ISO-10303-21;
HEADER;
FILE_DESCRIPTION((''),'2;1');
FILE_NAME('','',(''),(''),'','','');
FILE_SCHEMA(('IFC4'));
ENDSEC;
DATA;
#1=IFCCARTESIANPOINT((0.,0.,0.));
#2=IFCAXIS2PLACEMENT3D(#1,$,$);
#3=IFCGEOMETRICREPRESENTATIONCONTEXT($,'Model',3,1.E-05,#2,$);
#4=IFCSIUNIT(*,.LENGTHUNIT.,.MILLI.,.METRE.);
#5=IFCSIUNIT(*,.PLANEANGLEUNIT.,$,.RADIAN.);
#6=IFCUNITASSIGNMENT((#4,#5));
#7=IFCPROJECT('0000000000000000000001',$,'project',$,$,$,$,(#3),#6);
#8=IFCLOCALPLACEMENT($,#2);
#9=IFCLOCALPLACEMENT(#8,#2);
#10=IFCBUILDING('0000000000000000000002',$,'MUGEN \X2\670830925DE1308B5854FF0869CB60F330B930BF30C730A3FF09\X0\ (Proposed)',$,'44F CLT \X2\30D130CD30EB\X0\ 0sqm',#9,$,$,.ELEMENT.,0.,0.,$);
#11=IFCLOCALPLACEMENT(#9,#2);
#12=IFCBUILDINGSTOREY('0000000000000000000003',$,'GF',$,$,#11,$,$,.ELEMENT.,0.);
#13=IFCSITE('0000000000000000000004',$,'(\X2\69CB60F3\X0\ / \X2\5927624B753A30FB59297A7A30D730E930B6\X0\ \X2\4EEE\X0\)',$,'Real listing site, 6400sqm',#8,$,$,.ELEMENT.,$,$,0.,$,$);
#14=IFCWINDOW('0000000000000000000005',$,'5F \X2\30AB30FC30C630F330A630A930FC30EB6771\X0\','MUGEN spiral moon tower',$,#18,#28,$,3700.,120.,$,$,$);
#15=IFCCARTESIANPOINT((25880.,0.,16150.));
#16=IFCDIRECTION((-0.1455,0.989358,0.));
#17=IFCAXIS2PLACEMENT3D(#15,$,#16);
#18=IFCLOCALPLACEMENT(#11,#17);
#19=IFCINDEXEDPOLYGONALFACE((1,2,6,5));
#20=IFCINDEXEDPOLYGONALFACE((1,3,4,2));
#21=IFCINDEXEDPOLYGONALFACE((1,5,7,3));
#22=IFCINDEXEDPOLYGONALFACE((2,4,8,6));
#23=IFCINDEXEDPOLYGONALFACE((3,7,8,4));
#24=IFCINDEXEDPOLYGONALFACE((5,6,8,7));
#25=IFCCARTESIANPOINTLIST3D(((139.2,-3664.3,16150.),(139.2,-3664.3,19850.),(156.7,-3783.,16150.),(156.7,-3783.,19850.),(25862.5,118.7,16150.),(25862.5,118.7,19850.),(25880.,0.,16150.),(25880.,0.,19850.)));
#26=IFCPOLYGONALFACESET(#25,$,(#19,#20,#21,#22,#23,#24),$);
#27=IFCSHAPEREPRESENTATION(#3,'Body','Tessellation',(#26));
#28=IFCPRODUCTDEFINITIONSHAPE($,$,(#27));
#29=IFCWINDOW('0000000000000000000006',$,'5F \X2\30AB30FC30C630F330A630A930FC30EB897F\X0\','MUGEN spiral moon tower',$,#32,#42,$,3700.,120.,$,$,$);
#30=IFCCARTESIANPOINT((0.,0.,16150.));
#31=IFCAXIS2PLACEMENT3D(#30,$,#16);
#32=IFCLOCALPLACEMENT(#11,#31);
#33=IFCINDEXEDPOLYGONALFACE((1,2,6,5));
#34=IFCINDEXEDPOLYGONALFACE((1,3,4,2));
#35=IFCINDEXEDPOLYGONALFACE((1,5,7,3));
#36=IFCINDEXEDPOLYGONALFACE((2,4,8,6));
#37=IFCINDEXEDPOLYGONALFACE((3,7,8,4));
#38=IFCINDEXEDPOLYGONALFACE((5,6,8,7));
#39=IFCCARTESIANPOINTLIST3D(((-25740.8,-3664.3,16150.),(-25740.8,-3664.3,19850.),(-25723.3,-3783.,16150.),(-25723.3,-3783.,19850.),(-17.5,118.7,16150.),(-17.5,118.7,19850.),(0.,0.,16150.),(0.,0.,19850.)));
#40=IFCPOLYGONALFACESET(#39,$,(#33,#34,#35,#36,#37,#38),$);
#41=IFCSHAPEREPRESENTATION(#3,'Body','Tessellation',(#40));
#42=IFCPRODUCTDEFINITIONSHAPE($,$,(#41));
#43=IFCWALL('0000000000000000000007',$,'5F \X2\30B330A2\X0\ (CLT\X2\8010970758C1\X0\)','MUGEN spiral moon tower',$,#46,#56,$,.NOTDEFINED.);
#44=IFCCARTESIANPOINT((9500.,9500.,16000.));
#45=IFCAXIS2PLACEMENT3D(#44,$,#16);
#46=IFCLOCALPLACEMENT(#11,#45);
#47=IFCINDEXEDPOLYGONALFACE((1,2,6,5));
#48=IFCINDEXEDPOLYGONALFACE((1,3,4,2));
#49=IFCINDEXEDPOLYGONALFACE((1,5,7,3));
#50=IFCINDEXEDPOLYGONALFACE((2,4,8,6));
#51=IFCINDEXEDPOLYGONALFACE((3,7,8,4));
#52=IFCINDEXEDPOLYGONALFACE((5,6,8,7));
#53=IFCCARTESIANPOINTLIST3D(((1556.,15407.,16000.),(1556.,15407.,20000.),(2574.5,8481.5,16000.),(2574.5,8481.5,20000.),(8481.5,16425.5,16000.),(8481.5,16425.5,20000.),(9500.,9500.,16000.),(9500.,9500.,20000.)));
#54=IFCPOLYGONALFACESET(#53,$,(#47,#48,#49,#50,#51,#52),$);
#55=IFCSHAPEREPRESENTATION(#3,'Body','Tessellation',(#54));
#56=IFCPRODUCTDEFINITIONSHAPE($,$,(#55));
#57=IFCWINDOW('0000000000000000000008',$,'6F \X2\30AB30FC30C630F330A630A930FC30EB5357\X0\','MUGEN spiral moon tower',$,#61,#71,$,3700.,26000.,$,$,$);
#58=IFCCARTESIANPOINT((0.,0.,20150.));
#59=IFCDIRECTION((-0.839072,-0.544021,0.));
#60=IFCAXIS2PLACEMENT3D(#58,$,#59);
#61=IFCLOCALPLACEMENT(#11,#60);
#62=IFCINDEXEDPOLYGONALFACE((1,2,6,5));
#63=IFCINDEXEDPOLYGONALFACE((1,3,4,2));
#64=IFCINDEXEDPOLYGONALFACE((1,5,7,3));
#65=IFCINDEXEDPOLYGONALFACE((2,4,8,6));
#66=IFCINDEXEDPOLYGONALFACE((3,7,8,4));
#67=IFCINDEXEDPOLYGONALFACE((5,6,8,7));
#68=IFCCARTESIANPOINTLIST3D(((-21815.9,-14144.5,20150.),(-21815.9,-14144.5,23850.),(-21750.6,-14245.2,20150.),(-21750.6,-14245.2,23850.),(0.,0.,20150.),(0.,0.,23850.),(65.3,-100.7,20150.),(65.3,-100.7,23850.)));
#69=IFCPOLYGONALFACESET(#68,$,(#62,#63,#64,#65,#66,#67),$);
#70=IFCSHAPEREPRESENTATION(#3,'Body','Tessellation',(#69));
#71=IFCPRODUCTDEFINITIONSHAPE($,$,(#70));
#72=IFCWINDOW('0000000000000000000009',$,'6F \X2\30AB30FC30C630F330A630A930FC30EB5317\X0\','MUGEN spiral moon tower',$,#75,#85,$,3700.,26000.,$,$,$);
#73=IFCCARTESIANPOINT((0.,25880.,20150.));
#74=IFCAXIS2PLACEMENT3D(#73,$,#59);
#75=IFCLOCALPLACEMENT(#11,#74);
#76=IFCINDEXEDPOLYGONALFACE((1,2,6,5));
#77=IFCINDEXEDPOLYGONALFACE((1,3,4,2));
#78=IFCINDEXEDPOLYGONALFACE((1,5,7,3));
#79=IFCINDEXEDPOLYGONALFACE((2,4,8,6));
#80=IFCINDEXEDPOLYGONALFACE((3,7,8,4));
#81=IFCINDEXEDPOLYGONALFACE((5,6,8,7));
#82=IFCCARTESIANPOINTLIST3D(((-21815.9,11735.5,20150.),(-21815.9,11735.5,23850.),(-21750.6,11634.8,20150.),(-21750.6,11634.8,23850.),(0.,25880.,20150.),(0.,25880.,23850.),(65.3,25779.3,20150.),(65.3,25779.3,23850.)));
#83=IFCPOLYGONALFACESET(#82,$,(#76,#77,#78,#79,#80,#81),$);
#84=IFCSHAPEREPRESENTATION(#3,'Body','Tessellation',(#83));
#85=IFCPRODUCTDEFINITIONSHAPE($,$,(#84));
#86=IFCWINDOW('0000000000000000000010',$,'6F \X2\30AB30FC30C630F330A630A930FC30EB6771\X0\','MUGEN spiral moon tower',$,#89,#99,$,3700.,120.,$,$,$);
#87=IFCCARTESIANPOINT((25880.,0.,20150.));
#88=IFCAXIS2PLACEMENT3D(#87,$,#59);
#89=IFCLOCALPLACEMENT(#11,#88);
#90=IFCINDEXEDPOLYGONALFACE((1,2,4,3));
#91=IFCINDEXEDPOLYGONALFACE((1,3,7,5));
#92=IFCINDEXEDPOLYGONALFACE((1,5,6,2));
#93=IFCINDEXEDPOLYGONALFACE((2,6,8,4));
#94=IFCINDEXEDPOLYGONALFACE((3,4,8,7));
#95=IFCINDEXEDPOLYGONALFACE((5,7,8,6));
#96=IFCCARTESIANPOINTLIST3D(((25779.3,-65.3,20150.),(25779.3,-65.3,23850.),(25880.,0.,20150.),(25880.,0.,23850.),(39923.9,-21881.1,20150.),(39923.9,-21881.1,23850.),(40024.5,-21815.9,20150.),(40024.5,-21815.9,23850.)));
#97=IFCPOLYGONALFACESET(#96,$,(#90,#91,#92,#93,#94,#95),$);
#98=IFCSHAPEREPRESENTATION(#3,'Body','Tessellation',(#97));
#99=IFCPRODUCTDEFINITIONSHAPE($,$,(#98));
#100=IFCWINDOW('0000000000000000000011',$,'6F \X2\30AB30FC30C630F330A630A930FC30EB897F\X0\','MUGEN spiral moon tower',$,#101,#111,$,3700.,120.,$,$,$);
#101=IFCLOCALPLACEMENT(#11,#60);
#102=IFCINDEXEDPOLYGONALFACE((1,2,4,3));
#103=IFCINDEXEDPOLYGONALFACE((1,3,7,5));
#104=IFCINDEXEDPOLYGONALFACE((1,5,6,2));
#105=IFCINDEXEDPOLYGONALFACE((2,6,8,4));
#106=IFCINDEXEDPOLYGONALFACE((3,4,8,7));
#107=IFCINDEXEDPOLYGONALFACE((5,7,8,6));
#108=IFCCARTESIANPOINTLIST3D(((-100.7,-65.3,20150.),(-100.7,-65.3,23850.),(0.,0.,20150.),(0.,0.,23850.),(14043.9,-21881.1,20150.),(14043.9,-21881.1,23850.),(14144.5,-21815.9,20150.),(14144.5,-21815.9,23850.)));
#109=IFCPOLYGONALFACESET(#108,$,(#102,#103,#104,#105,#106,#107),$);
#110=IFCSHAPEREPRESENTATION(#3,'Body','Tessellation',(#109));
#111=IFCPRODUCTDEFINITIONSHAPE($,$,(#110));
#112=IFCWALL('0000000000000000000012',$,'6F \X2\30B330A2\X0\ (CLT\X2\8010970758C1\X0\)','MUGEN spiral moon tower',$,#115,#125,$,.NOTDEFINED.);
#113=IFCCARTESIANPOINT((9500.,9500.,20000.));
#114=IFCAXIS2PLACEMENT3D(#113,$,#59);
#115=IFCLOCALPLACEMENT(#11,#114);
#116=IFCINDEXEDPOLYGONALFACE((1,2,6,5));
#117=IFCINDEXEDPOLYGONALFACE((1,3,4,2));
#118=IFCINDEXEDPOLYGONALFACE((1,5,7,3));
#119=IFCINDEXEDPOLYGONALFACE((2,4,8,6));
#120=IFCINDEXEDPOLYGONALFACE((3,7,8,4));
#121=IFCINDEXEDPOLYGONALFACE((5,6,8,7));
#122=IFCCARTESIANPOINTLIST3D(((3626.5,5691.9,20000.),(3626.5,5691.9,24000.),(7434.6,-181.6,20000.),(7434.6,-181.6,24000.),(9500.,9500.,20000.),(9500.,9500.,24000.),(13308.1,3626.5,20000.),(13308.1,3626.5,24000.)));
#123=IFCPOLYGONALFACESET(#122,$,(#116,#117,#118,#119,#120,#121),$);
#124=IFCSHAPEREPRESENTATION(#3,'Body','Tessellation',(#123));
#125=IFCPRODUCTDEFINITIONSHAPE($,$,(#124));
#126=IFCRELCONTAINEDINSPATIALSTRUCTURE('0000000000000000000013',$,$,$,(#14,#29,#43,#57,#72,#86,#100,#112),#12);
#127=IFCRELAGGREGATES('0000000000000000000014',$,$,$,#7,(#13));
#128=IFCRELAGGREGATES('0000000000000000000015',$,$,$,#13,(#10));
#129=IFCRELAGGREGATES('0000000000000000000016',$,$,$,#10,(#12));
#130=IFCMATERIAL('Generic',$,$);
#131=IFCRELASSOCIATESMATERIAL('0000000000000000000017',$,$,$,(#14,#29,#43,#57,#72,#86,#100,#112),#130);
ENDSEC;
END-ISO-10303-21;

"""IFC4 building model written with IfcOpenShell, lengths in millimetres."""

from ifc_helpers import new_model, si_unit, frame, frame_2d, origin, place, context, project, spatial, rectangle, extrude, material, element, save


model = new_model("IFC4")

# Units and contexts
model_context = context("Model", 3, precision=1e-05, world=origin())
ifc_project = project(units=[si_unit("LENGTHUNIT", "METRE", prefix="MILLI"), si_unit("PLANEANGLEUNIT", "RADIAN")], contexts=[model_context])

# Site, building, storey
site_placement = place(None, origin())
site = spatial("IfcSite", under=ifc_project, at=site_placement, Name="(構想 / 大手町・天空プラザ 仮)", ObjectType="Real listing site, 6400sqm", CompositionType="ELEMENT", RefElevation=0.0)
building_placement = place(site_placement, origin())
building = spatial("IfcBuilding", under=site, at=building_placement, Name="MUGEN 月を巡る塔（構想スタディ） (Proposed)", ObjectType="44F CLT パネル 0sqm", CompositionType="ELEMENT", ElevationOfRefHeight=0.0, ElevationOfTerrain=0.0)
storey_placement = place(building_placement, origin())
storey = spatial("IfcBuildingStorey", under=building, at=storey_placement, Name="GF", CompositionType="ELEMENT", Elevation=0.0)

# Shared definitions
ifc_material = material(Name="Generic")

# Windows
window_1_placement = place(storey_placement, frame((25880.0, 0.0, 16150.0), x_axis=(-0.1455, 0.989358, 0.0)))
element("IfcWindow", 1, at=window_1_placement, inside=storey, material=ifc_material, Name="5F カーテンウォール東", Description="MUGEN spiral moon tower", OverallHeight=3700.0, OverallWidth=120.0, context=model_context, shape_type="SweptSolid", body=[
    extrude(rectangle(XDim=120.0, YDim=26000.0, at=frame_2d((60.0, 13000.0))), frame((25880.0, 0.0, 16150.0), x_axis=(-0.1455, 0.989358, 0.0)), (0.0, 0.0, 1.0), 3700.0),
])
window_2_placement = place(storey_placement, frame((0.0, 0.0, 16150.0), x_axis=(-0.1455, 0.989358, 0.0)))
element("IfcWindow", 2, at=window_2_placement, inside=storey, material=ifc_material, Name="5F カーテンウォール西", Description="MUGEN spiral moon tower", OverallHeight=3700.0, OverallWidth=120.0, context=model_context, shape_type="SweptSolid", body=[
    extrude(rectangle(XDim=120.0, YDim=26000.0, at=frame_2d((60.0, 13000.0))), frame((0.0, 0.0, 16150.0), x_axis=(-0.1455, 0.989358, 0.0)), (0.0, 0.0, 1.0), 3700.0),
])

# Wall
wall_1_placement = place(storey_placement, frame((9500.0, 9500.0, 16000.0), x_axis=(-0.1455, 0.989358, 0.0)))
element("IfcWall", 3, at=wall_1_placement, inside=storey, material=ifc_material, Name="5F コア (CLT耐震壁)", Description="MUGEN spiral moon tower", PredefinedType="NOTDEFINED", context=model_context, shape_type="SweptSolid", body=[
    extrude(rectangle(XDim=7000.0, YDim=7000.0, at=frame_2d((3500.0, 3500.0))), frame((9500.0, 9500.0, 16000.0), x_axis=(-0.1455, 0.989358, 0.0)), (0.0, 0.0, 1.0), 4000.0),
])

# Windows
window_3_placement = place(storey_placement, frame((0.0, 0.0, 20150.0), x_axis=(-0.839072, -0.544021, 0.0)))
element("IfcWindow", 4, at=window_3_placement, inside=storey, material=ifc_material, Name="6F カーテンウォール南", Description="MUGEN spiral moon tower", OverallHeight=3700.0, OverallWidth=26000.0, context=model_context, shape_type="SweptSolid", body=[
    extrude(rectangle(XDim=26000.0, YDim=120.0, at=frame_2d((13000.0, 60.0))), frame((0.0, 0.0, 20150.0), x_axis=(-0.839072, -0.544021, 0.0)), (0.0, 0.0, 1.0), 3700.0),
])
window_4_placement = place(storey_placement, frame((0.0, 25880.0, 20150.0), x_axis=(-0.839072, -0.544021, 0.0)))
element("IfcWindow", 5, at=window_4_placement, inside=storey, material=ifc_material, Name="6F カーテンウォール北", Description="MUGEN spiral moon tower", OverallHeight=3700.0, OverallWidth=26000.0, context=model_context, shape_type="SweptSolid", body=[
    extrude(rectangle(XDim=26000.0, YDim=120.0, at=frame_2d((13000.0, 60.0))), frame((0.0, 25880.0, 20150.0), x_axis=(-0.839072, -0.544021, 0.0)), (0.0, 0.0, 1.0), 3700.0),
])
window_5_placement = place(storey_placement, frame((25880.0, 0.0, 20150.0), x_axis=(-0.839072, -0.544021, 0.0)))
element("IfcWindow", 6, at=window_5_placement, inside=storey, material=ifc_material, Name="6F カーテンウォール東", Description="MUGEN spiral moon tower", OverallHeight=3700.0, OverallWidth=120.0, context=model_context, shape_type="SweptSolid", body=[
    extrude(rectangle(XDim=120.0, YDim=26000.0, at=frame_2d((60.0, 13000.0))), frame((25880.0, 0.0, 20150.0), x_axis=(-0.839072, -0.544021, 0.0)), (0.0, 0.0, 1.0), 3700.0),
])
window_6_placement = place(storey_placement, frame((0.0, 0.0, 20150.0), x_axis=(-0.839072, -0.544021, 0.0)))
element("IfcWindow", 7, at=window_6_placement, inside=storey, material=ifc_material, Name="6F カーテンウォール西", Description="MUGEN spiral moon tower", OverallHeight=3700.0, OverallWidth=120.0, context=model_context, shape_type="SweptSolid", body=[
    extrude(rectangle(XDim=120.0, YDim=26000.0, at=frame_2d((60.0, 13000.0))), frame((0.0, 0.0, 20150.0), x_axis=(-0.839072, -0.544021, 0.0)), (0.0, 0.0, 1.0), 3700.0),
])

# Wall
wall_2_placement = place(storey_placement, frame((9500.0, 9500.0, 20000.0), x_axis=(-0.839072, -0.544021, 0.0)))
element("IfcWall", 8, at=wall_2_placement, inside=storey, material=ifc_material, Name="6F コア (CLT耐震壁)", Description="MUGEN spiral moon tower", PredefinedType="NOTDEFINED", context=model_context, shape_type="SweptSolid", body=[
    extrude(rectangle(XDim=7000.0, YDim=7000.0, at=frame_2d((3500.0, 3500.0))), frame((9500.0, 9500.0, 20000.0), x_axis=(-0.839072, -0.544021, 0.0)), (0.0, 0.0, 1.0), 4000.0),
])

save(model, "model.ifc")
